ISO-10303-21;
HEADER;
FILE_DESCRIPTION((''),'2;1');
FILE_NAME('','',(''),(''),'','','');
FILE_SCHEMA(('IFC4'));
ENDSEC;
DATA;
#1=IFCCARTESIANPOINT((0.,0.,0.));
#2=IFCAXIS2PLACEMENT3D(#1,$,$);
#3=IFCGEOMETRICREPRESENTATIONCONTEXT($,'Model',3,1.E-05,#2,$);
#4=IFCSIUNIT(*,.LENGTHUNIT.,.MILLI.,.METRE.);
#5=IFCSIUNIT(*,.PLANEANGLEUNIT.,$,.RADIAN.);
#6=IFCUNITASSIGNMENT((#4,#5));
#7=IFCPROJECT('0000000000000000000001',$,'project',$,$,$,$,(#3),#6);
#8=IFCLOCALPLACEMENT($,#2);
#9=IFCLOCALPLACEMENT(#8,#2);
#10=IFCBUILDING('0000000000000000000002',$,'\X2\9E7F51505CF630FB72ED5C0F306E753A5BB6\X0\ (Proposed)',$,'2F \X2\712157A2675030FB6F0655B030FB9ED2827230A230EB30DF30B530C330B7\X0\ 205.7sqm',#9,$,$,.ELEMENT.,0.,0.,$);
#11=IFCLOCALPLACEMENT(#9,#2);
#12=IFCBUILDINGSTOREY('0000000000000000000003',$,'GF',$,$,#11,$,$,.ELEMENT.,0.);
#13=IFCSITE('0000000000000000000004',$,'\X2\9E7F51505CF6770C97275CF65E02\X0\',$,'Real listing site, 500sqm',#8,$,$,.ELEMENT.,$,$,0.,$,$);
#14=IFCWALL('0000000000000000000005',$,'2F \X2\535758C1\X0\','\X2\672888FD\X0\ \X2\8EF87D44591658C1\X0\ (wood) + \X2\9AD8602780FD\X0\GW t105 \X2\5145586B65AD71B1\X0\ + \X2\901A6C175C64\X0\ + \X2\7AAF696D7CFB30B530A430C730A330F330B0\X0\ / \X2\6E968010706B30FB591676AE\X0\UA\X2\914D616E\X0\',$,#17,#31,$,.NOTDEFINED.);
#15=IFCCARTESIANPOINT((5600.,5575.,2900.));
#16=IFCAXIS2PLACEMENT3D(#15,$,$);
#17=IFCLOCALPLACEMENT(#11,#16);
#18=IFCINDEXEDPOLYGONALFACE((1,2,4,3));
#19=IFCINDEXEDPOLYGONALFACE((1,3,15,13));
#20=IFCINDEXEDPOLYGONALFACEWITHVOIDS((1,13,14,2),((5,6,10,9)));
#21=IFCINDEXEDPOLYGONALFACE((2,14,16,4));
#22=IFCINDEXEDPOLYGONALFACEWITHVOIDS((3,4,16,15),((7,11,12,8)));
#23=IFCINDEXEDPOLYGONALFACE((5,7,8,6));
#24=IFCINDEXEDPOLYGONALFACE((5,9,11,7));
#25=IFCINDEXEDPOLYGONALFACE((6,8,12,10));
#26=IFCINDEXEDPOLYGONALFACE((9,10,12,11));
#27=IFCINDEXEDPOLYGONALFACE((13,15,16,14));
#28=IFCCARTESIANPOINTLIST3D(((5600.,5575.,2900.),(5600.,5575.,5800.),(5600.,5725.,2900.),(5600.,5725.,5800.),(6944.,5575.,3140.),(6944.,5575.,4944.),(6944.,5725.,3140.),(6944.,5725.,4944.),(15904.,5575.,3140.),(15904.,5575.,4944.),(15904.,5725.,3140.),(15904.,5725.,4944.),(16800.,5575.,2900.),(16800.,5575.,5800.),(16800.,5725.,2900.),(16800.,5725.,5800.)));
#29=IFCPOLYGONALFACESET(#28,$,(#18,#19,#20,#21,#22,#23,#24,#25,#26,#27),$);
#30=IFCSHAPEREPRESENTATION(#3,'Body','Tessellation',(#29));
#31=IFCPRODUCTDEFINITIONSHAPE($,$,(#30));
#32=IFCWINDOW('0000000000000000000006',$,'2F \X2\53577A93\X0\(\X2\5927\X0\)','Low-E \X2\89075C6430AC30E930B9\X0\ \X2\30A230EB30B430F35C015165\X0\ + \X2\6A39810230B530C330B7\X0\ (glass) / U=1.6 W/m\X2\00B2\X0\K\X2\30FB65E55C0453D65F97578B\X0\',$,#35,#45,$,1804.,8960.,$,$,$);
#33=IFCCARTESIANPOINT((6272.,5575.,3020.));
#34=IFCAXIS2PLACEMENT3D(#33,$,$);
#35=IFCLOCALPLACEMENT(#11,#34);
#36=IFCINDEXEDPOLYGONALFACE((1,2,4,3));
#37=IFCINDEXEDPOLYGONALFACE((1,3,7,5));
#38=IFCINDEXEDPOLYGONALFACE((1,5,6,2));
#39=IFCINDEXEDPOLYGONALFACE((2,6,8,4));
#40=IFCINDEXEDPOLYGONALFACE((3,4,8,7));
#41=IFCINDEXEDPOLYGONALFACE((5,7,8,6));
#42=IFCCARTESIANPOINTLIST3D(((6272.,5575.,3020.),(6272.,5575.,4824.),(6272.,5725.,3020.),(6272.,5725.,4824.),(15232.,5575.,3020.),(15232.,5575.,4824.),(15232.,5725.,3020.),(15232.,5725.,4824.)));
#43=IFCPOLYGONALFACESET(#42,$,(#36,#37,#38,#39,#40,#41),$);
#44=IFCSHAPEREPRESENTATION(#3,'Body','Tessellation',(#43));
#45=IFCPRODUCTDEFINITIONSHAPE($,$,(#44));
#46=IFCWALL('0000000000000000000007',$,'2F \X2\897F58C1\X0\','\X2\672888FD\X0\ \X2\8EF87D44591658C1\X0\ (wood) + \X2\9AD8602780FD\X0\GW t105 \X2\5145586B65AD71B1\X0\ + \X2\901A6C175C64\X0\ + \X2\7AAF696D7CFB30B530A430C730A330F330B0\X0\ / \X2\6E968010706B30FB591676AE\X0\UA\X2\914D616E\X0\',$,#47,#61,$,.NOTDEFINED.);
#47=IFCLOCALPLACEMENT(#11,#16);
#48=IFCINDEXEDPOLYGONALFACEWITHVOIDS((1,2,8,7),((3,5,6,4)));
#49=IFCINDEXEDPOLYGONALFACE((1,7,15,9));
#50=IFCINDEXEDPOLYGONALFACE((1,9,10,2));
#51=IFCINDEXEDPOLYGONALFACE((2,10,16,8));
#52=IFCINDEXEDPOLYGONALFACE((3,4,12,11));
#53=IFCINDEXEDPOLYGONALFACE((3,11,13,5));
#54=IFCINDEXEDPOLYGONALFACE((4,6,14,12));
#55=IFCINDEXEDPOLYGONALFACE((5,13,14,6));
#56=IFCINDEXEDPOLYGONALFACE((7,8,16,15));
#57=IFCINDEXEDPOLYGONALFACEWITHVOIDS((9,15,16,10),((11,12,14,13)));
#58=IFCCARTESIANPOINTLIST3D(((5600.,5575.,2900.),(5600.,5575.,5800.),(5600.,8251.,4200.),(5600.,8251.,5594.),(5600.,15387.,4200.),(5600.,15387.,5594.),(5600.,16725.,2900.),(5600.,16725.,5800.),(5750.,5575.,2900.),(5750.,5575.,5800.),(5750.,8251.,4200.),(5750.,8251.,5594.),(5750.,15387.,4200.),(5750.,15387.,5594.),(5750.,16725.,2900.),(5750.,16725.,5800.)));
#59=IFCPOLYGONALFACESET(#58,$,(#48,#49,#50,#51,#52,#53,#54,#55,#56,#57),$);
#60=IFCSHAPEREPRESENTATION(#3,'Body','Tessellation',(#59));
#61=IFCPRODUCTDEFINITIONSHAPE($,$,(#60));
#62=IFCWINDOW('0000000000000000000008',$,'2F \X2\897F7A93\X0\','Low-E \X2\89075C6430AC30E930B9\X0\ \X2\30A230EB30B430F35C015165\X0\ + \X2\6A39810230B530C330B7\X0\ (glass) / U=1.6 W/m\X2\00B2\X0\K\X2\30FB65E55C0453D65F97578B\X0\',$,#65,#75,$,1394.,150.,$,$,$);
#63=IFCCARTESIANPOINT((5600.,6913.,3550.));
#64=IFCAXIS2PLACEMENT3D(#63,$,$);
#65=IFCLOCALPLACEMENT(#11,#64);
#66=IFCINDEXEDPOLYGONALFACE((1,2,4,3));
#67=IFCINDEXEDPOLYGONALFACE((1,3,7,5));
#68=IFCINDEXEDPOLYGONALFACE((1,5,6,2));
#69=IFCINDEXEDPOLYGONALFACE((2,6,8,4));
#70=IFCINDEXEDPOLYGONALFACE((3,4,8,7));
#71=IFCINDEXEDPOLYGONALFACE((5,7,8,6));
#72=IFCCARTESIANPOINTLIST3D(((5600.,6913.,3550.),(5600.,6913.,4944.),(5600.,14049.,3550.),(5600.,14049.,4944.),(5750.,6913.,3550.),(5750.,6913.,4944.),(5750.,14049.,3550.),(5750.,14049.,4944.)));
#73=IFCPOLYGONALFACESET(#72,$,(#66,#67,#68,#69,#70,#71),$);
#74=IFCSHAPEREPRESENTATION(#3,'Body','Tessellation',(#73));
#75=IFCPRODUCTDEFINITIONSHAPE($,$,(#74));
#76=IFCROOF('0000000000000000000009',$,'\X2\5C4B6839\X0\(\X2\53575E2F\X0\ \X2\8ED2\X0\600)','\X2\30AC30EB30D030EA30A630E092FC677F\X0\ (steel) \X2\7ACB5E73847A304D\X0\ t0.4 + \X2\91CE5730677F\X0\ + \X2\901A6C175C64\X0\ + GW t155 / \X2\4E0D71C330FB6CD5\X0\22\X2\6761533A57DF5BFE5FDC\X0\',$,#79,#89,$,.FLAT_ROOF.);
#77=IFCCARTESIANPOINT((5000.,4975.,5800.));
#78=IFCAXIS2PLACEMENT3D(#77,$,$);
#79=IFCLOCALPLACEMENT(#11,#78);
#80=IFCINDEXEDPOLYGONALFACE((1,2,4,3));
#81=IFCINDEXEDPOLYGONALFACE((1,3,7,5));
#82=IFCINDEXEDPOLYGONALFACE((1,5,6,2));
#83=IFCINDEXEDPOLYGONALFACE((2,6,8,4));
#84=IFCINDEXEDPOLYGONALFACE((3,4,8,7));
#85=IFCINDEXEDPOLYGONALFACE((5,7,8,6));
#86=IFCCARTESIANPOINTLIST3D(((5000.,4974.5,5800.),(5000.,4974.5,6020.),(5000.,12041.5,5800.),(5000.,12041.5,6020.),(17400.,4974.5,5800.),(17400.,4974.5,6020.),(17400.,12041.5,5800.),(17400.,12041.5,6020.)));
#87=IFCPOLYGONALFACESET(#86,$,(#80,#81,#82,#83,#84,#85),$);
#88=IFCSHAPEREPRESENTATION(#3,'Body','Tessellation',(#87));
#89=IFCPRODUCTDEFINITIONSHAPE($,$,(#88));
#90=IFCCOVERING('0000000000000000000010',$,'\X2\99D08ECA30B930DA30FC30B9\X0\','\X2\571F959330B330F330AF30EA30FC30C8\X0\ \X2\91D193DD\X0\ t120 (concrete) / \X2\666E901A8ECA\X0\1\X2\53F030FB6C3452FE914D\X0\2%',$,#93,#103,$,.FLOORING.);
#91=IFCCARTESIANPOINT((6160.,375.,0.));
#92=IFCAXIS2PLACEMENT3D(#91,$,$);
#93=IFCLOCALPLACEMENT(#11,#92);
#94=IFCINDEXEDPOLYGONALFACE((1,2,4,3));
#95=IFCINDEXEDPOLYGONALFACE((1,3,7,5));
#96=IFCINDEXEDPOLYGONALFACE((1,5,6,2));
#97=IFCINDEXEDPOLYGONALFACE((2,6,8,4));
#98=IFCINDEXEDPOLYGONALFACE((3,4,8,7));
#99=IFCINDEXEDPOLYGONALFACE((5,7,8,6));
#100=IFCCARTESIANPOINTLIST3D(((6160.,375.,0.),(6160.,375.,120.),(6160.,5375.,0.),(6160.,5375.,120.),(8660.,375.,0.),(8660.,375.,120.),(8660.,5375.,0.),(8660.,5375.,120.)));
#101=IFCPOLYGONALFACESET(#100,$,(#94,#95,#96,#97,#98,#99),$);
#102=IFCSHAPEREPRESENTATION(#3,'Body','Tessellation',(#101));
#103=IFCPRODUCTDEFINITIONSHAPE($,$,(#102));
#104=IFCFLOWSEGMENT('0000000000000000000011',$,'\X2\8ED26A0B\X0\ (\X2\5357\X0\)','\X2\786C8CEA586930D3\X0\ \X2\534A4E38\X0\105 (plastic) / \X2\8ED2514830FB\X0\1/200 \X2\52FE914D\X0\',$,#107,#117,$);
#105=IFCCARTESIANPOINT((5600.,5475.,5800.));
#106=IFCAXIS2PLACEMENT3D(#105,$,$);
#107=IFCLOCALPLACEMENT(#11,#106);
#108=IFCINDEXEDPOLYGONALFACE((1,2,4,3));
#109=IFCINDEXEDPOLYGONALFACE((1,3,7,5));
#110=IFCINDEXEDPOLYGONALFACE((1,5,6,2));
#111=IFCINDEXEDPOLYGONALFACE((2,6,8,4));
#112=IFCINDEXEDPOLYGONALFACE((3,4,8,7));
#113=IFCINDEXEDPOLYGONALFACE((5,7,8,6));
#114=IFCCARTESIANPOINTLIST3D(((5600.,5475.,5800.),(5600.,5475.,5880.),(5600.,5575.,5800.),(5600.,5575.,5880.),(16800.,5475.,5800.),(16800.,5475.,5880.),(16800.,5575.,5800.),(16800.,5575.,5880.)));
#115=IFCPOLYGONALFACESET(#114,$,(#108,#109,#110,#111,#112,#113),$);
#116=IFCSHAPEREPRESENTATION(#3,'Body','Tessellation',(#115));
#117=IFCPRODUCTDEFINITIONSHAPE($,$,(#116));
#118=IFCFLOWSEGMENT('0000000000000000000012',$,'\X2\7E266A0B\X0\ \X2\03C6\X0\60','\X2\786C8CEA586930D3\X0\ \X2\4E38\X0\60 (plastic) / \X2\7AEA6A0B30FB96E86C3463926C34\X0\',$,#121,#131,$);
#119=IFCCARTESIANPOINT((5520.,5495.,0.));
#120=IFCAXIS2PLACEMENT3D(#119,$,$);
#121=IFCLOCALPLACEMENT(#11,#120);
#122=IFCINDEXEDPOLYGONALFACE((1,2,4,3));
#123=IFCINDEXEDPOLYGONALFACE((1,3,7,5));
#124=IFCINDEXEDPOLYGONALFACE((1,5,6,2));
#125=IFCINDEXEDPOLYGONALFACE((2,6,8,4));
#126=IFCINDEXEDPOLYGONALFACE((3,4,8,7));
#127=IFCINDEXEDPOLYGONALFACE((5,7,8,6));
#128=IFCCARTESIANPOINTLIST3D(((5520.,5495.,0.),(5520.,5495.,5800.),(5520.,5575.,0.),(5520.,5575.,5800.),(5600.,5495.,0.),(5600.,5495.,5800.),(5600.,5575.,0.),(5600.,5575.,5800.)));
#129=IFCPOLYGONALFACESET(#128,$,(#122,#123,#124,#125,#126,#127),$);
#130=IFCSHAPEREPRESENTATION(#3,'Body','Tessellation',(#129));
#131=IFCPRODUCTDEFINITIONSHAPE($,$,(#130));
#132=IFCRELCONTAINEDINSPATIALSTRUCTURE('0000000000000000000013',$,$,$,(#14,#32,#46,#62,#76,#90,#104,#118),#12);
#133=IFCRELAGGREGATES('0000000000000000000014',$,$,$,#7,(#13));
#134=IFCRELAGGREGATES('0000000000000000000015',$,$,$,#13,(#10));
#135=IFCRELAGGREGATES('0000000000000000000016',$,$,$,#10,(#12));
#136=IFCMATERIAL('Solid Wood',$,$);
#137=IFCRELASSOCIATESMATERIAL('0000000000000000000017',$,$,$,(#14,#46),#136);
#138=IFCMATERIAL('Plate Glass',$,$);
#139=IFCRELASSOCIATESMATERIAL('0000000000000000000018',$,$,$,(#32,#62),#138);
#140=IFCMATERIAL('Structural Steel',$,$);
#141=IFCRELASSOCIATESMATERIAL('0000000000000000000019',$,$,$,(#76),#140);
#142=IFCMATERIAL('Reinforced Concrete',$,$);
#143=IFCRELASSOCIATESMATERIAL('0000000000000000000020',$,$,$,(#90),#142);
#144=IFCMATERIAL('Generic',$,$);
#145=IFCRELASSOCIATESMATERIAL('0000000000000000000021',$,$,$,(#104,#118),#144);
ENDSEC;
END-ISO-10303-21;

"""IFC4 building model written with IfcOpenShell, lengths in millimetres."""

from ifc_helpers import new_model, si_unit, frame, frame_2d, origin, place, context, project, spatial, rectangle, extrude, material, element, fill, save


model = new_model("IFC4")

# Units and contexts
model_context = context("Model", 3, precision=1e-05, world=origin())
ifc_project = project(units=[si_unit("LENGTHUNIT", "METRE", prefix="MILLI"), si_unit("PLANEANGLEUNIT", "RADIAN")], contexts=[model_context])

# Site, building, storey
site_placement = place(None, origin())
site = spatial("IfcSite", under=ifc_project, at=site_placement, Name="鹿児島県霧島市", ObjectType="Real listing site, 500sqm", CompositionType="ELEMENT", RefElevation=0.0)
building_placement = place(site_placement, origin())
building = spatial("IfcBuilding", under=site, at=building_placement, Name="鹿児島・狭小の町家 (Proposed)", ObjectType="2F 無垢材・漆喰・黒色アルミサッシ 205.7sqm", CompositionType="ELEMENT", ElevationOfRefHeight=0.0, ElevationOfTerrain=0.0)
storey_placement = place(building_placement, origin())
storey = spatial("IfcBuildingStorey", under=building, at=storey_placement, Name="GF", CompositionType="ELEMENT", Elevation=0.0)

# Shared definitions
ifc_material_1 = material(Name="Solid Wood")

# Shared definitions
ifc_material_2 = material(Name="Reinforced Concrete")

# Shared definitions
ifc_material_3 = material(Name="Plate Glass")

# Walls, openings, windows
wall_1_placement = place(storey_placement, frame((5600.0, 5575.0, 2900.0)))
wall_1 = element("IfcWall", 1, at=wall_1_placement, inside=storey, material=ifc_material_1, Name="2F 南壁", Description="木製 軸組外壁 (wood) + 高性能GW t105 充填断熱 + 通気層 + 窯業系サイディング / 準耐火・外皮UA配慮", PredefinedType="NOTDEFINED", context=model_context, shape_type="SweptSolid", body=[
    extrude(rectangle(XDim=11200.0, YDim=150.0, at=frame_2d((5600.0, 75.0))), frame((5600.0, 5575.0, 2900.0)), (0.0, 0.0, 1.0), 2900.0),
])
opening_1_placement = place(storey_placement, frame((6272.0, 5575.0, 3020.0)))
opening_1 = element("IfcOpeningElement", 2, at=opening_1_placement, cuts=wall_1, PredefinedType="NOTDEFINED", context=model_context, shape_type="SweptSolid", body=[
    extrude(rectangle(XDim=8960.0, YDim=150.0, at=frame_2d((4480.0, 75.0))), frame((6272.0, 5575.0, 3020.0)), (0.0, 0.0, 1.0), 1804.0),
])
window_1_placement = place(storey_placement, frame((6272.0, 5575.0, 3020.0)))
window_1 = element("IfcWindow", 3, at=window_1_placement, inside=storey, material=ifc_material_3, Name="2F 南窓(大)", Description="Low-E 複層ガラス アルゴン封入 + 樹脂サッシ (glass) / U=1.6 W/m²K・日射取得型", OverallHeight=1804.0, OverallWidth=8960.0, context=model_context, shape_type="SweptSolid", body=[
    extrude(rectangle(XDim=8960.0, YDim=150.0, at=frame_2d((4480.0, 75.0))), frame((6272.0, 5575.0, 3020.0)), (0.0, 0.0, 1.0), 1804.0),
])
fill(opening_1, window_1)
wall_2_placement = place(storey_placement, frame((5600.0, 5575.0, 2900.0)))
wall_2 = element("IfcWall", 4, at=wall_2_placement, inside=storey, material=ifc_material_1, Name="2F 西壁", Description="木製 軸組外壁 (wood) + 高性能GW t105 充填断熱 + 通気層 + 窯業系サイディング / 準耐火・外皮UA配慮", PredefinedType="NOTDEFINED", context=model_context, shape_type="SweptSolid", body=[
    extrude(rectangle(XDim=150.0, YDim=11150.0, at=frame_2d((75.0, 5575.0))), frame((5600.0, 5575.0, 2900.0)), (0.0, 0.0, 1.0), 2900.0),
])
opening_2_placement = place(storey_placement, frame((5600.0, 6913.0, 3550.0)))
opening_2 = element("IfcOpeningElement", 5, at=opening_2_placement, cuts=wall_2, PredefinedType="NOTDEFINED", context=model_context, shape_type="SweptSolid", body=[
    extrude(rectangle(XDim=150.0, YDim=7136.0, at=frame_2d((75.0, 3568.0))), frame((5600.0, 6913.0, 3550.0)), (0.0, 0.0, 1.0), 1394.0),
])
window_2_placement = place(storey_placement, frame((5600.0, 6913.0, 3550.0)))
window_2 = element("IfcWindow", 6, at=window_2_placement, inside=storey, material=ifc_material_3, Name="2F 西窓", Description="Low-E 複層ガラス アルゴン封入 + 樹脂サッシ (glass) / U=1.6 W/m²K・日射取得型", OverallHeight=1394.0, OverallWidth=150.0, context=model_context, shape_type="SweptSolid", body=[
    extrude(rectangle(XDim=150.0, YDim=7136.0, at=frame_2d((75.0, 3568.0))), frame((5600.0, 6913.0, 3550.0)), (0.0, 0.0, 1.0), 1394.0),
])
fill(opening_2, window_2)

# Roof
ifc_material_4 = material(Name="Structural Steel")
for number, where, name in (
    (7, (5000.0, 4975.0, 5800.0), "屋根(南帯 軒600)"),
):
    element("IfcRoof", number, at=place(storey_placement, frame(where)), inside=storey, material=ifc_material_4, Name=name, Description="ガルバリウム鋼板 (steel) 立平葺き t0.4 + 野地板 + 通気層 + GW t155 / 不燃・法22条区域対応", PredefinedType="FLAT_ROOF", context=model_context, shape_type="SweptSolid", body=[
        extrude(rectangle(XDim=12400.0, YDim=7067.0, at=frame_2d((6200.0, 3533.0))), frame((5000.0, 4975.0, 5800.0)), (0.0, 0.0, 1.0), 220.0),
    ])

# Covering
covering_placement = place(storey_placement, frame((6160.0, 375.0, 0.0)))
element("IfcCovering", 8, at=covering_placement, inside=storey, material=ifc_material_2, Name="駐車スペース", Description="土間コンクリート 金鏝 t120 (concrete) / 普通車1台・水勾配2%", PredefinedType="FLOORING", context=model_context, shape_type="SweptSolid", body=[
    extrude(rectangle(XDim=2500.0, YDim=5000.0, at=frame_2d((1250.0, 2500.0))), frame((6160.0, 375.0, 0.0)), (0.0, 0.0, 1.0), 120.0),
])

# Flow segments
ifc_material_5 = material(Name="Generic")
flow_segment_1_placement = place(storey_placement, frame((5600.0, 5475.0, 5800.0)))
element("IfcFlowSegment", 9, at=flow_segment_1_placement, inside=storey, material=ifc_material_5, Name="軒樋 (南)", Description="硬質塩ビ 半丸105 (plastic) / 軒先・1/200 勾配", context=model_context, shape_type="SweptSolid", body=[
    extrude(rectangle(XDim=11200.0, YDim=100.0, at=frame_2d((5600.0, 50.0))), frame((5600.0, 5475.0, 5800.0)), (0.0, 0.0, 1.0), 80.0),
])
flow_segment_2_placement = place(storey_placement, frame((5520.0, 5495.0, 0.0)))
element("IfcFlowSegment", 10, at=flow_segment_2_placement, inside=storey, material=ifc_material_5, Name="縦樋 φ60", Description="硬質塩ビ 丸60 (plastic) / 竪樋・雨水排水", context=model_context, shape_type="SweptSolid", body=[
    extrude(rectangle(XDim=80.0, YDim=80.0, at=frame_2d((40.0, 40.0))), frame((5520.0, 5495.0, 0.0)), (0.0, 0.0, 1.0), 5800.0),
])

save(model, "model.ifc")
